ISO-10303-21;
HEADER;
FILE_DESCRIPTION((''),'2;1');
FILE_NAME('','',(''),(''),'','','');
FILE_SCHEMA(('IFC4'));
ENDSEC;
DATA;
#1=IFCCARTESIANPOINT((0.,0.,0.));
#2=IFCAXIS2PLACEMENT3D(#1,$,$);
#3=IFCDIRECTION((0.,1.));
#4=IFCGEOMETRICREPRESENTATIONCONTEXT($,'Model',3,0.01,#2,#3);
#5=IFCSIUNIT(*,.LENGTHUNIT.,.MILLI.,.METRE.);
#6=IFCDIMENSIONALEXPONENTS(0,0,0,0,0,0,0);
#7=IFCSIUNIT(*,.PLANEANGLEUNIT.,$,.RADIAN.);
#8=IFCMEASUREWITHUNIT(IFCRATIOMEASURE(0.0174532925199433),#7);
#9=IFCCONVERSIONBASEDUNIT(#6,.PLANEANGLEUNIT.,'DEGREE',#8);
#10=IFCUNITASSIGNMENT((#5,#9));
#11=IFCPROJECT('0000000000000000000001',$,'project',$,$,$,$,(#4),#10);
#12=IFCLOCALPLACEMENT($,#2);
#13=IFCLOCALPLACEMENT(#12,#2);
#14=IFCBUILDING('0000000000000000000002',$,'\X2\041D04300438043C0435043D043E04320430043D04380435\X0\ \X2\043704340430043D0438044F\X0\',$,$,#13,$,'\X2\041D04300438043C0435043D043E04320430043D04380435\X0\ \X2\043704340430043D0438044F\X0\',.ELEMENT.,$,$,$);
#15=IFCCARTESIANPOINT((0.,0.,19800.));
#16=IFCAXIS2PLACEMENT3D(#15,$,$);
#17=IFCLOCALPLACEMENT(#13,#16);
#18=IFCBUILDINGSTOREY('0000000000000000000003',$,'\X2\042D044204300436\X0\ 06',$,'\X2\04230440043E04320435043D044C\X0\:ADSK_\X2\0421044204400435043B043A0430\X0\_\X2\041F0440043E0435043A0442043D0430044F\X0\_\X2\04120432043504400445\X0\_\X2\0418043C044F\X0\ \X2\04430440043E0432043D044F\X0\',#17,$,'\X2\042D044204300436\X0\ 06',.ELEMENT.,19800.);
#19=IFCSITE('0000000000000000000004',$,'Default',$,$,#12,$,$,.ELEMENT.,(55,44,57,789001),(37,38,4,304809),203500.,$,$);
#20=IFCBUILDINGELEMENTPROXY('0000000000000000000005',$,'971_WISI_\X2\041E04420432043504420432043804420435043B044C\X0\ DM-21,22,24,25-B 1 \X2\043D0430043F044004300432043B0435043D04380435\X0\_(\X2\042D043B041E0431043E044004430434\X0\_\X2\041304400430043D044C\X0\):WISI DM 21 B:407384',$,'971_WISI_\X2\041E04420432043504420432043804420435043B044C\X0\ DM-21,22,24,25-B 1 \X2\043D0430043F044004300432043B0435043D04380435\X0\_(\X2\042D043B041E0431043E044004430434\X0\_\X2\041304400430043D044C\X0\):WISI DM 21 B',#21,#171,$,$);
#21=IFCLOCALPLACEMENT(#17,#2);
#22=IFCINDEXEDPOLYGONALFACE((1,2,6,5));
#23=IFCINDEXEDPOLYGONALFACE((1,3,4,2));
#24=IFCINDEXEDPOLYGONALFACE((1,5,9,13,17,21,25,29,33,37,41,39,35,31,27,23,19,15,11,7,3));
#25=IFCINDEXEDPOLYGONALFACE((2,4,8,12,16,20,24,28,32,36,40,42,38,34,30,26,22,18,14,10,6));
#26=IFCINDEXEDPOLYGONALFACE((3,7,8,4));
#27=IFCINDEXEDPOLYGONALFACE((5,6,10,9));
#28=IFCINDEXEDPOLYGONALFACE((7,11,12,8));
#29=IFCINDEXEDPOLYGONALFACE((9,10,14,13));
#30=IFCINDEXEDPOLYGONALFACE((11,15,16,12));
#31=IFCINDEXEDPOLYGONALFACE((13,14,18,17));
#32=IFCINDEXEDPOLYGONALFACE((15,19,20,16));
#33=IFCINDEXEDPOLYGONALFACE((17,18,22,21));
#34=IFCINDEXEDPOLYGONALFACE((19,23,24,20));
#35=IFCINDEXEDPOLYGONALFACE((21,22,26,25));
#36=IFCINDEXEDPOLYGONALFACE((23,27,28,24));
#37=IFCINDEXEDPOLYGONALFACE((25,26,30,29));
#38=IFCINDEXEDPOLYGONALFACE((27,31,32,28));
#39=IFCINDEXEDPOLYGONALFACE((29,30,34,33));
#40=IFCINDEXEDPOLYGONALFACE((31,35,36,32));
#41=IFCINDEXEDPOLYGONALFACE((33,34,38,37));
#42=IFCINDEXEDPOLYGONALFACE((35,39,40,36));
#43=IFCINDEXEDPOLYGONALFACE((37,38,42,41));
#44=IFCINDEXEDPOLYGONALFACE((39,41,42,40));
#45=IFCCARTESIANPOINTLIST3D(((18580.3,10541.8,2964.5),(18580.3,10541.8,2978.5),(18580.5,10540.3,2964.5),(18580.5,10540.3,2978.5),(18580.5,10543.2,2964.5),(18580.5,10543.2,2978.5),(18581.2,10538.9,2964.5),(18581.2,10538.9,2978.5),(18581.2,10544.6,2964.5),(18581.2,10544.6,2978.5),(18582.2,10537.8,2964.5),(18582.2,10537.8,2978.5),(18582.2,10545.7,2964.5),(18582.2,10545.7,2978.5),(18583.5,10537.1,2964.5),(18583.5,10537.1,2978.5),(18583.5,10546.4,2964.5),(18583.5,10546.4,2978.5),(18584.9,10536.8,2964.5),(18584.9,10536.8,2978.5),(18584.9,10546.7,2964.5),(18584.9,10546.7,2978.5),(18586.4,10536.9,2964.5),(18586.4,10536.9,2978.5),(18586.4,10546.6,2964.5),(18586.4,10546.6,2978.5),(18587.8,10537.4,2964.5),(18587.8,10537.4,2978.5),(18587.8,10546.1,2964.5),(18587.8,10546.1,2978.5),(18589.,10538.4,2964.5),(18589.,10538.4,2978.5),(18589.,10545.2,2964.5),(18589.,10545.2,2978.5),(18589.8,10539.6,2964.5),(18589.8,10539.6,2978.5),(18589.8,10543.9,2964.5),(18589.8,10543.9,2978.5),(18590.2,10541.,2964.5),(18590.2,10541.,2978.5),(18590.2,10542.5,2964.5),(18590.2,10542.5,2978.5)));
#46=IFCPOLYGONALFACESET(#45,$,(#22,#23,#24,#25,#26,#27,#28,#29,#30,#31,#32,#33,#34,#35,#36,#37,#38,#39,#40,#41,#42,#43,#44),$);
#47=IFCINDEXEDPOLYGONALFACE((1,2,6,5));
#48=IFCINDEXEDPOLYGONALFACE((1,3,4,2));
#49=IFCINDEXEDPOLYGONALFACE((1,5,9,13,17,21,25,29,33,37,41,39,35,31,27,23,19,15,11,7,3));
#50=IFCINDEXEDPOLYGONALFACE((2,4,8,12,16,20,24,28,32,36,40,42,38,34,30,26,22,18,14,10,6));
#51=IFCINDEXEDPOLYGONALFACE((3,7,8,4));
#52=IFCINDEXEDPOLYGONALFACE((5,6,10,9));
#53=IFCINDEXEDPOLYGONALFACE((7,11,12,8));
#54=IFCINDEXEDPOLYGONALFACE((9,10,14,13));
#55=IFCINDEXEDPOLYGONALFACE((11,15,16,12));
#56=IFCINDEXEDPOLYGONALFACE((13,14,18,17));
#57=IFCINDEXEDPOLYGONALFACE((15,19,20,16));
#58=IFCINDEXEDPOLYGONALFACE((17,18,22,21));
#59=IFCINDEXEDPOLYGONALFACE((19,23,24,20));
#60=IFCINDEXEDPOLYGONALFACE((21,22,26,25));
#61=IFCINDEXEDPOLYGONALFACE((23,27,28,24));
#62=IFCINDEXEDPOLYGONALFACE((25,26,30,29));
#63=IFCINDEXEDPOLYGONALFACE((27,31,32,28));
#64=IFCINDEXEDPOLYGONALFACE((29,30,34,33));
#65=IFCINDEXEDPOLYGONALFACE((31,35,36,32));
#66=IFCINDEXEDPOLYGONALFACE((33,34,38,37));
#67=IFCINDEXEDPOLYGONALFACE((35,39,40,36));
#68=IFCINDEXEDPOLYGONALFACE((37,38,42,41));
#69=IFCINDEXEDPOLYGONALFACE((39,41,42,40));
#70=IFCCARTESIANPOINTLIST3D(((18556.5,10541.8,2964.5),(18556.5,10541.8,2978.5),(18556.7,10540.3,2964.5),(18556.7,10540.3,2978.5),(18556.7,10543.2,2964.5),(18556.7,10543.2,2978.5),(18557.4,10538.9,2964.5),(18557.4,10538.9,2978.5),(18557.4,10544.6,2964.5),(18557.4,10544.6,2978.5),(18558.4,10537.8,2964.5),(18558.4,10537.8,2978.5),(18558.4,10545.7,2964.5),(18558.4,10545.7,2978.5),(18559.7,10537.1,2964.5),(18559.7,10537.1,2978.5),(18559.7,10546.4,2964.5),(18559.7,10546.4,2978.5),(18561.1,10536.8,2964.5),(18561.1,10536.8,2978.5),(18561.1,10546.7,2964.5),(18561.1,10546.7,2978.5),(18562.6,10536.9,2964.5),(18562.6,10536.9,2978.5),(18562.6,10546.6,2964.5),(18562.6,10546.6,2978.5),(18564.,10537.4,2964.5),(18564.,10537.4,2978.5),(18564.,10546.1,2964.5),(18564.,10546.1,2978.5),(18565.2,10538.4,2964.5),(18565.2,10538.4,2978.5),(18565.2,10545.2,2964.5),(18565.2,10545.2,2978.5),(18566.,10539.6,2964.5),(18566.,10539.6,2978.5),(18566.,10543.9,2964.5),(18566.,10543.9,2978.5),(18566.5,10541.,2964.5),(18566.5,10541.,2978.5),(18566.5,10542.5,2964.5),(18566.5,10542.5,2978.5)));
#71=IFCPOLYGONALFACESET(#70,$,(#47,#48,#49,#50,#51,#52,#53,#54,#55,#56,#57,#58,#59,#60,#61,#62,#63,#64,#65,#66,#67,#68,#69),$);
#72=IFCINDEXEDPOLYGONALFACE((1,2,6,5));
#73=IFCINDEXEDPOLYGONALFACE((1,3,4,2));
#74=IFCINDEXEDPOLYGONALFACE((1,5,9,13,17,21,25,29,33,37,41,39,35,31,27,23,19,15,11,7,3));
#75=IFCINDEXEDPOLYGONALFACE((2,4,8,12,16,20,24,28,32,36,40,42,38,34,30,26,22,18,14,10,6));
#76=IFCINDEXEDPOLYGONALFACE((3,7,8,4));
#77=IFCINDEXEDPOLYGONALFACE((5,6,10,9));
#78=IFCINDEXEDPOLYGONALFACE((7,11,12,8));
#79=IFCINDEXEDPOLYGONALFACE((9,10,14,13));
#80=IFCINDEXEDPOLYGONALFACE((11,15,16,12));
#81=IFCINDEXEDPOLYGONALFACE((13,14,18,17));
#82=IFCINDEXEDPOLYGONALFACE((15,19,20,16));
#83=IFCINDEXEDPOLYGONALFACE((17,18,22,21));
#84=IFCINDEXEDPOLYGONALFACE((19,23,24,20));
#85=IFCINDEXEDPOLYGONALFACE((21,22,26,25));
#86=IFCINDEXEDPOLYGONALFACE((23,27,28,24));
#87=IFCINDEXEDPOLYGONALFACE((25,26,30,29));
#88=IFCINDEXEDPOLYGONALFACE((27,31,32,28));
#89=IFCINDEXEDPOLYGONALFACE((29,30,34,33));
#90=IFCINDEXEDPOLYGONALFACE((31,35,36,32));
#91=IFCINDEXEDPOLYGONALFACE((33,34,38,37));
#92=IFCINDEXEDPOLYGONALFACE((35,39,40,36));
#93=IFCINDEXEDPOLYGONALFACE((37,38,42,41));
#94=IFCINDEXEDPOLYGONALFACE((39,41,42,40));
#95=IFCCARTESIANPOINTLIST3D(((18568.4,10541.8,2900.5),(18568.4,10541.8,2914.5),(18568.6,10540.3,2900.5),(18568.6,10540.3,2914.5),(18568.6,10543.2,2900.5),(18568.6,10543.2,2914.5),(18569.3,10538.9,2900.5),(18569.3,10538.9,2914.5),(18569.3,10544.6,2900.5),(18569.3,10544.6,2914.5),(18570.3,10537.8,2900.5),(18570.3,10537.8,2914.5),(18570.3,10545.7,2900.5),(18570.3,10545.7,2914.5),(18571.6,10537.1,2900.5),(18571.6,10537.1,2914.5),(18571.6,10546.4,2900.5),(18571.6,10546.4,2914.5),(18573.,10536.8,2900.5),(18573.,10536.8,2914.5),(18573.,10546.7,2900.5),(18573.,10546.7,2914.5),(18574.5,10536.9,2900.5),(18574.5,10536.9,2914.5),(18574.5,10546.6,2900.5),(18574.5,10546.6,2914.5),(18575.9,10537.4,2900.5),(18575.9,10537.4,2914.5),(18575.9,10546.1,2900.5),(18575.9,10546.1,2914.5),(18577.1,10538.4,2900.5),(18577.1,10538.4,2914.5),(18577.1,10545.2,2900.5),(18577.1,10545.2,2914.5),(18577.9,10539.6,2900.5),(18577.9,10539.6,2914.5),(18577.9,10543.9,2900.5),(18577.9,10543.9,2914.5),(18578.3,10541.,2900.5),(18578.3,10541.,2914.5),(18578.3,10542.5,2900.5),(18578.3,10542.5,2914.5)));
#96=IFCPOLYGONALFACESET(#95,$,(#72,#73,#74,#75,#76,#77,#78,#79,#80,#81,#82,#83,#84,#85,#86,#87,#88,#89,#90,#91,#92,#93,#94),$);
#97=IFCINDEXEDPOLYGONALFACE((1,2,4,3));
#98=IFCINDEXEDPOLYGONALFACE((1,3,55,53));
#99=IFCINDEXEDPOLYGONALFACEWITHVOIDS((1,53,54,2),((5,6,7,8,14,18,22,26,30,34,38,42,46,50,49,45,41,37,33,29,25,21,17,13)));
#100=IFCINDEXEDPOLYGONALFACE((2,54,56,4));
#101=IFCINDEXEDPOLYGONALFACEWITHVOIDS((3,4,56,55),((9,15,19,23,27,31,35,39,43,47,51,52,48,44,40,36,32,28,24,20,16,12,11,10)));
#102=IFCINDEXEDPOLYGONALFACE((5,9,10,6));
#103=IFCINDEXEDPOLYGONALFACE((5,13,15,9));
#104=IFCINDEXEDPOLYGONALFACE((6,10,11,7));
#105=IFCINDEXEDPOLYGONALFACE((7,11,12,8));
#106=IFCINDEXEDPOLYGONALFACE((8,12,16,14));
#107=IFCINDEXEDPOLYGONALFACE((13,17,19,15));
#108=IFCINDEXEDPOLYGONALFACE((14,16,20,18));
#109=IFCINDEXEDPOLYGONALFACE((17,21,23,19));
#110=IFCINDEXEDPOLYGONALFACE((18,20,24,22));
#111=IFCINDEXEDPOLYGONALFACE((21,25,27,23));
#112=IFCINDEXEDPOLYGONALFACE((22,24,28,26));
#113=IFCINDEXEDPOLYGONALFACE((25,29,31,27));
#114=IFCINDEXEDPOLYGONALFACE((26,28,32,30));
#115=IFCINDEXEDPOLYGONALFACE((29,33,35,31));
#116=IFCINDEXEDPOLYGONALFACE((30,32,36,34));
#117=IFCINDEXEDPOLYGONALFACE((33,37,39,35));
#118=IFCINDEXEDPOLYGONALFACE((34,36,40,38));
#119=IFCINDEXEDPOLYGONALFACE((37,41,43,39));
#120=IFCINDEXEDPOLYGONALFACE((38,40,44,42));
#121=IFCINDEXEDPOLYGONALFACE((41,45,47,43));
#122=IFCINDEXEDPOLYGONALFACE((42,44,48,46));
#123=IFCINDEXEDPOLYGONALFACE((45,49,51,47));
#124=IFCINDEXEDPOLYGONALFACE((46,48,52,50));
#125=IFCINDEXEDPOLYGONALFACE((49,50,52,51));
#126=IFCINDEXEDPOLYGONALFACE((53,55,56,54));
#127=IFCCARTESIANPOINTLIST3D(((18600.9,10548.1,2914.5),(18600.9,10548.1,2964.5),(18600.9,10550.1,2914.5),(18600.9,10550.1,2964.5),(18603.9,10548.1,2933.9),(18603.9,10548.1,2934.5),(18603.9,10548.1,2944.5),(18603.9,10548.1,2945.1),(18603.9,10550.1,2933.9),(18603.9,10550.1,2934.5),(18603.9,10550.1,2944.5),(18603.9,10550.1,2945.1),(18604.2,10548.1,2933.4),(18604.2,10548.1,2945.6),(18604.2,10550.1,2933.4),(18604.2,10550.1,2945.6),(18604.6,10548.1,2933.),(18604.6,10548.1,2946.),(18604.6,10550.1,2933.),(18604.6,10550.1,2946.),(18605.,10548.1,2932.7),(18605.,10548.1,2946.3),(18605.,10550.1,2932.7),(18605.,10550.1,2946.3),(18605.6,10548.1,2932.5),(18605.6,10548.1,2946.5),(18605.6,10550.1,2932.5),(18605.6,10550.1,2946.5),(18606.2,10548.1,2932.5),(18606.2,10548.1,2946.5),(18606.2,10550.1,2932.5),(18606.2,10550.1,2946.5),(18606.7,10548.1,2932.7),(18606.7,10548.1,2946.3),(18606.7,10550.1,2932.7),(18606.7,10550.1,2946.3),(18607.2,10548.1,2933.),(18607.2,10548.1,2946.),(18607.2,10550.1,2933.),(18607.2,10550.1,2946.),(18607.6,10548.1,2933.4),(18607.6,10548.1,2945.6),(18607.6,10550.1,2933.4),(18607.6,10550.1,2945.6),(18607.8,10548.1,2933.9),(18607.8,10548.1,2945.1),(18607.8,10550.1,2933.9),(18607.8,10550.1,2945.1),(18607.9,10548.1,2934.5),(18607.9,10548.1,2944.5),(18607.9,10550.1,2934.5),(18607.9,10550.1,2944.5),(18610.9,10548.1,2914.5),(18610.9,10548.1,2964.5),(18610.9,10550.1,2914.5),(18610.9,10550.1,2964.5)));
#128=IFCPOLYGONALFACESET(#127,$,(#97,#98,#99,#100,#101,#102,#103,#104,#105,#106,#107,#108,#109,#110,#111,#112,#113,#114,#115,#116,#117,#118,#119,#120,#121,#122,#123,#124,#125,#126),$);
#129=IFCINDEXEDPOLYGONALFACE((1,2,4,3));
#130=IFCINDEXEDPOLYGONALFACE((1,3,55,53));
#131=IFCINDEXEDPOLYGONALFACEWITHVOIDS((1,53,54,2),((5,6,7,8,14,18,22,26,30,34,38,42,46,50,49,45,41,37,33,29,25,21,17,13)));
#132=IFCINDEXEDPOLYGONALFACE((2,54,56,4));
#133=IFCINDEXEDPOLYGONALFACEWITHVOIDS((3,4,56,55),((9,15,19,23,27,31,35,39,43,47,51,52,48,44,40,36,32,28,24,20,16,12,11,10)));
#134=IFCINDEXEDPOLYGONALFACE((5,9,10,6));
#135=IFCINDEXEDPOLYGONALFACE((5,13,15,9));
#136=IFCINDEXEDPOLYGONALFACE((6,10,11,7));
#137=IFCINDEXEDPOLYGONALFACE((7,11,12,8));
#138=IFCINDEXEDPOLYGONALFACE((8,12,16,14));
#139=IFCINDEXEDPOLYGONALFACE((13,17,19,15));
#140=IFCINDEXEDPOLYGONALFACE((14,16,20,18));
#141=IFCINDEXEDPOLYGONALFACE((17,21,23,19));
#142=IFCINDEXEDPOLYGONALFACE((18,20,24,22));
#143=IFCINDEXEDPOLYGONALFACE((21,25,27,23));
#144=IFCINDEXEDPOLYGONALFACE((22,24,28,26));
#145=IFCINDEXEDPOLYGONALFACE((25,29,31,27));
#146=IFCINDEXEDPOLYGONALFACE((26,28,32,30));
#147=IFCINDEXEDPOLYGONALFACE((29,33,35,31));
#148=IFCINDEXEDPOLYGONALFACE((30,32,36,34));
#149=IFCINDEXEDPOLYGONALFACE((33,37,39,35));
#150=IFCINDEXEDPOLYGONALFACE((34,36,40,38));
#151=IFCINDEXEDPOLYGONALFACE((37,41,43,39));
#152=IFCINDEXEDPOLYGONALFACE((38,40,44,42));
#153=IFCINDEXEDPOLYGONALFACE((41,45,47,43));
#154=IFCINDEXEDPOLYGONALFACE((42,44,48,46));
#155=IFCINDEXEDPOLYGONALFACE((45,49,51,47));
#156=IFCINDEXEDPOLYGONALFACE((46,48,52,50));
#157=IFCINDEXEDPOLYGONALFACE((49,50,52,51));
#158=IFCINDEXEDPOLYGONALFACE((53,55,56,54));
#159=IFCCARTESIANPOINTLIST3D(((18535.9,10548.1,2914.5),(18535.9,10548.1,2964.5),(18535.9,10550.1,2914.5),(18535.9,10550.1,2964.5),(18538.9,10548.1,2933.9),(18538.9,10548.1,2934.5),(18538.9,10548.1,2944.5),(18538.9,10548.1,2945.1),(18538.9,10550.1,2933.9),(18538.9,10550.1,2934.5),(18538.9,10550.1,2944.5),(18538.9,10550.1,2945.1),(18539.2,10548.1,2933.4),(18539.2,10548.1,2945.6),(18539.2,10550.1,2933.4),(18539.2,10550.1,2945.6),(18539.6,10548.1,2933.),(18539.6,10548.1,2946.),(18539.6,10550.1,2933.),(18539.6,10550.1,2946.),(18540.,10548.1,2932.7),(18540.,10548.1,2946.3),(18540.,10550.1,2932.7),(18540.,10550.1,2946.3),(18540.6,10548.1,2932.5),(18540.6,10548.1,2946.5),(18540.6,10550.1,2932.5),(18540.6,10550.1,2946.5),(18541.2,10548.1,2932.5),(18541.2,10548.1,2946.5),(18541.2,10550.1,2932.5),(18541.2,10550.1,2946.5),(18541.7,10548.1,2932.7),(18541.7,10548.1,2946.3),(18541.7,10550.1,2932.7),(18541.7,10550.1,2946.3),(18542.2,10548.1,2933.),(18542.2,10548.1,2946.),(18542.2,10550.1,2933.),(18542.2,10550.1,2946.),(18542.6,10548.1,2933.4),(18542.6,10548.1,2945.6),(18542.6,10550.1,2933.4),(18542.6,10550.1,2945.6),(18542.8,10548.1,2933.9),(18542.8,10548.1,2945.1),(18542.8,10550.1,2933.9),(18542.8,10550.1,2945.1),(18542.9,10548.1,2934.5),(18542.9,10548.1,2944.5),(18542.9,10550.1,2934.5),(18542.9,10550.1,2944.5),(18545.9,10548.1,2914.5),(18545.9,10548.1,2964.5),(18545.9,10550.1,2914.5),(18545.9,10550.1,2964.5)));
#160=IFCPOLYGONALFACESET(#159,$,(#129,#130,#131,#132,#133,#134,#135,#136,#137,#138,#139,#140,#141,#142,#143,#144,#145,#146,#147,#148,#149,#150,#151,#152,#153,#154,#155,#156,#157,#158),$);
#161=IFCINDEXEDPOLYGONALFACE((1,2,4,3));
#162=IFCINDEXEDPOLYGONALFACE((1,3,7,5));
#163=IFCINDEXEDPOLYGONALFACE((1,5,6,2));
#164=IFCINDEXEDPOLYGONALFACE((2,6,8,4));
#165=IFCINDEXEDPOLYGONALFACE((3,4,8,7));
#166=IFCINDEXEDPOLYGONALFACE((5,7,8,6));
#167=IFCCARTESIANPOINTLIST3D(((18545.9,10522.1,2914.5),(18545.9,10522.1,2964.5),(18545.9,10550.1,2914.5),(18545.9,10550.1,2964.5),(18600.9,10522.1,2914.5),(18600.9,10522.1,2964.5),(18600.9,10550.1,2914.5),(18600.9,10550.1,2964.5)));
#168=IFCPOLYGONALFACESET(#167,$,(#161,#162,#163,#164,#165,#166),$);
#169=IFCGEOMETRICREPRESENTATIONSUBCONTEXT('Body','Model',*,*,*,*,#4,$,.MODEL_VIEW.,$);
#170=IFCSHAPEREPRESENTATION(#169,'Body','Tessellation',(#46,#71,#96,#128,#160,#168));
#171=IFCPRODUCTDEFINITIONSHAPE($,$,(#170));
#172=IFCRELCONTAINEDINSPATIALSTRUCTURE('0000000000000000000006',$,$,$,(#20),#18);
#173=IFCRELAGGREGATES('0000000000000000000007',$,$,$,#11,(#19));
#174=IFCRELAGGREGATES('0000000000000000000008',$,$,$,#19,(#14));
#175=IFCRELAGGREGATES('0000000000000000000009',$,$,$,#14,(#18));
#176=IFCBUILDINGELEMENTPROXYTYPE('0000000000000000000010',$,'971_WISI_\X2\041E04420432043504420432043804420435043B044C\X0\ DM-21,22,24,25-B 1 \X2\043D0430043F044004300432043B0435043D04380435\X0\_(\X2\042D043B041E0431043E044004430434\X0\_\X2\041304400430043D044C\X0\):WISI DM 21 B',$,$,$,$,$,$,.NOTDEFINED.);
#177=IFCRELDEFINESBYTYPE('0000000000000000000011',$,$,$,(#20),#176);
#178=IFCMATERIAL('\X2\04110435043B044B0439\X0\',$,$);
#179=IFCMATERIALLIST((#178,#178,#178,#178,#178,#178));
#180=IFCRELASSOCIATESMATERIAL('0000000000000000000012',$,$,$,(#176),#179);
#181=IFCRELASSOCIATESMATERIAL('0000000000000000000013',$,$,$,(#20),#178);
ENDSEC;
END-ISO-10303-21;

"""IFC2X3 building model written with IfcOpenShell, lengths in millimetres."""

from ifc_helpers import new_model, entity, si_unit, converted_unit, direction, frame, frame_2d, origin, place, context, subcontext, project, spatial, polyline, circle_curve, parameter, trimmed, segment, composite_curve, rectangle, circle, outline, extrude, source, transform, mapped, material, material_list, type_object, type_shapes, element, save


model = new_model("IFC2X3")

# Units and contexts
model_context = context("Model", 3, precision=0.01, world=origin(), true_north=direction((0.0, 1.0)))
body_context = subcontext(model_context, "Body", "Model", "MODEL_VIEW")
ifc_project = project(units=[si_unit("LENGTHUNIT", "METRE", prefix="MILLI"), converted_unit("PLANEANGLEUNIT", "DEGREE", entity("IfcRatioMeasure", 0.0174532925199433), si_unit("PLANEANGLEUNIT", "RADIAN"), dimensions=[0, 0, 0, 0, 0, 0, 0])], contexts=[model_context])

# Site, building, storey
site_placement = place(None, frame((0.0, 0.0, 0.0)))
site = spatial("IfcSite", under=ifc_project, at=site_placement, Name="Default", CompositionType="ELEMENT", RefLatitude=(55, 44, 57, 789001), RefLongitude=(37, 38, 4, 304809), RefElevation=203500.0)
building_placement = place(site_placement, origin())
building = spatial("IfcBuilding", under=site, at=building_placement, Name="Наименование здания", LongName="Наименование здания", CompositionType="ELEMENT")
storey_placement = place(building_placement, frame((0.0, 0.0, 19800.0)))
storey = spatial("IfcBuildingStorey", under=building, at=storey_placement, Name="Этаж 06", ObjectType="Уровень:ADSK_Стрелка_Проектная_Вверх_Имя уровня", LongName="Этаж 06", CompositionType="ELEMENT", Elevation=19800.0)

# Building element proxy
ifc_material_1 = material(Name="Белый")
ifc_material_list_1 = material_list([ifc_material_1, ifc_material_1, ifc_material_1, ifc_material_1, ifc_material_1, ifc_material_1])
building_element_proxy_type_1 = type_object("IfcBuildingElementProxyType", Name="971_WISI_Ответвитель DM-21,22,24,25-B 1 направление_(ЭлОборуд_Грань):WISI DM 21 B", PredefinedType="NOTDEFINED", material=ifc_material_list_1)
shared_shape_1 = source(origin(), body_context, "Body", "SweptSolid", [
    extrude(circle(Radius=5.0, at=frame_2d((0.0, 0.0), x_axis=(1.0, 0.0))), frame((11.9, 25.0, 8.4), z_axis=(0.0, 1.0, 0.0), x_axis=(-1.0, 0.0, 0.0)), (0.0, 0.0, 1.0), 14.0),
    extrude(circle(Radius=5.0, at=frame_2d((0.0, 0.0), x_axis=(1.0, 0.0))), frame((-11.8, 25.0, 8.4), z_axis=(0.0, 1.0, 0.0), x_axis=(-1.0, 0.0, 0.0)), (0.0, 0.0, 1.0), 14.0),
    extrude(circle(Radius=5.0, at=frame_2d((0.0, 0.0), x_axis=(1.0, 0.0))), frame((0.0, -39.0, 8.4), z_axis=(0.0, 1.0, 0.0), x_axis=(-1.0, 0.0, 0.0)), (0.0, 0.0, 1.0), 14.0),
    extrude(outline(polyline([(-5.0, -25.0), (5.0, -25.0), (5.0, 25.0), (-5.0, 25.0), (-5.0, -25.0)]), holes=[composite_curve([segment(polyline([(2.0, 5.0), (2.0, -5.0)]), True, "CONTINUOUS"), segment(trimmed(circle_curve(frame_2d((0.0, -5.0), x_axis=(-1.0, 0.0)), 2.0), [parameter(0.0)], [parameter(180.0)], True, "PARAMETER"), False, "CONTINUOUS"), segment(polyline([(-2.0, -5.0), (-2.0, 5.0)]), True, "CONTINUOUS"), segment(trimmed(circle_curve(frame_2d((0.0, 5.0), x_axis=(-1.0, 0.0)), 2.0), [parameter(180.0)], [parameter(0.0)], True, "PARAMETER"), False, "CONTINUOUS")], self_intersect=False)]), frame((32.5, 0.0, 0.0), z_axis=(0.0, 0.0, 1.0), x_axis=(-1.0, 0.0, 0.0)), (0.0, 0.0, 1.0), 2.0),
    extrude(outline(polyline([(-5.0, -25.0), (5.0, -25.0), (5.0, 25.0), (-5.0, 25.0), (-5.0, -25.0)]), holes=[composite_curve([segment(polyline([(-2.0, -5.0), (-2.0, 5.0)]), True, "CONTINUOUS"), segment(trimmed(circle_curve(frame_2d((0.0, 5.0), x_axis=(-1.0, 0.0)), 2.0), [parameter(180.0)], [parameter(0.0)], True, "PARAMETER"), False, "CONTINUOUS"), segment(polyline([(2.0, 5.0), (2.0, -5.0)]), True, "CONTINUOUS"), segment(trimmed(circle_curve(frame_2d((0.0, -5.0), x_axis=(-1.0, 0.0)), 2.0), [parameter(0.0)], [parameter(180.0)], True, "PARAMETER"), False, "CONTINUOUS")], self_intersect=False)]), frame((-32.5, 0.0, 0.0), z_axis=(0.0, 0.0, 1.0), x_axis=(-1.0, 0.0, 0.0)), (0.0, 0.0, 1.0), 2.0),
    extrude(rectangle(XDim=55.0, YDim=50.0, at=frame_2d((0.0, 0.0), x_axis=(1.0, 0.0))), frame((0.0, 0.0, 0.0), z_axis=(0.0, 0.0, 1.0), x_axis=(-1.0, 0.0, 0.0)), (0.0, 0.0, 1.0), 28.0),
])
type_shapes(building_element_proxy_type_1, [shared_shape_1])
for number, where, z_axis, x_axis, name in (
    (1, (18573.4, 10550.1, 2939.5), (0.0, -1.0, 0.0), (1.0, 0.0, 0.0), "971_WISI_Ответвитель DM-21,22,24,25-B 1 направление_(ЭлОборуд_Грань):WISI DM 21 B:407384"),
):
    element("IfcBuildingElementProxy", number, at=place(storey_placement, frame(where, z_axis=z_axis, x_axis=x_axis)), inside=storey, type_object=building_element_proxy_type_1, material=ifc_material_1, Name=name, ObjectType="971_WISI_Ответвитель DM-21,22,24,25-B 1 направление_(ЭлОборуд_Грань):WISI DM 21 B", context=body_context, shape_type="MappedRepresentation", body=[
        mapped(shared_shape_1, transform((0.0, 0.0, 0.0), scale=1.0)),
    ])

save(model, "model.ifc")
